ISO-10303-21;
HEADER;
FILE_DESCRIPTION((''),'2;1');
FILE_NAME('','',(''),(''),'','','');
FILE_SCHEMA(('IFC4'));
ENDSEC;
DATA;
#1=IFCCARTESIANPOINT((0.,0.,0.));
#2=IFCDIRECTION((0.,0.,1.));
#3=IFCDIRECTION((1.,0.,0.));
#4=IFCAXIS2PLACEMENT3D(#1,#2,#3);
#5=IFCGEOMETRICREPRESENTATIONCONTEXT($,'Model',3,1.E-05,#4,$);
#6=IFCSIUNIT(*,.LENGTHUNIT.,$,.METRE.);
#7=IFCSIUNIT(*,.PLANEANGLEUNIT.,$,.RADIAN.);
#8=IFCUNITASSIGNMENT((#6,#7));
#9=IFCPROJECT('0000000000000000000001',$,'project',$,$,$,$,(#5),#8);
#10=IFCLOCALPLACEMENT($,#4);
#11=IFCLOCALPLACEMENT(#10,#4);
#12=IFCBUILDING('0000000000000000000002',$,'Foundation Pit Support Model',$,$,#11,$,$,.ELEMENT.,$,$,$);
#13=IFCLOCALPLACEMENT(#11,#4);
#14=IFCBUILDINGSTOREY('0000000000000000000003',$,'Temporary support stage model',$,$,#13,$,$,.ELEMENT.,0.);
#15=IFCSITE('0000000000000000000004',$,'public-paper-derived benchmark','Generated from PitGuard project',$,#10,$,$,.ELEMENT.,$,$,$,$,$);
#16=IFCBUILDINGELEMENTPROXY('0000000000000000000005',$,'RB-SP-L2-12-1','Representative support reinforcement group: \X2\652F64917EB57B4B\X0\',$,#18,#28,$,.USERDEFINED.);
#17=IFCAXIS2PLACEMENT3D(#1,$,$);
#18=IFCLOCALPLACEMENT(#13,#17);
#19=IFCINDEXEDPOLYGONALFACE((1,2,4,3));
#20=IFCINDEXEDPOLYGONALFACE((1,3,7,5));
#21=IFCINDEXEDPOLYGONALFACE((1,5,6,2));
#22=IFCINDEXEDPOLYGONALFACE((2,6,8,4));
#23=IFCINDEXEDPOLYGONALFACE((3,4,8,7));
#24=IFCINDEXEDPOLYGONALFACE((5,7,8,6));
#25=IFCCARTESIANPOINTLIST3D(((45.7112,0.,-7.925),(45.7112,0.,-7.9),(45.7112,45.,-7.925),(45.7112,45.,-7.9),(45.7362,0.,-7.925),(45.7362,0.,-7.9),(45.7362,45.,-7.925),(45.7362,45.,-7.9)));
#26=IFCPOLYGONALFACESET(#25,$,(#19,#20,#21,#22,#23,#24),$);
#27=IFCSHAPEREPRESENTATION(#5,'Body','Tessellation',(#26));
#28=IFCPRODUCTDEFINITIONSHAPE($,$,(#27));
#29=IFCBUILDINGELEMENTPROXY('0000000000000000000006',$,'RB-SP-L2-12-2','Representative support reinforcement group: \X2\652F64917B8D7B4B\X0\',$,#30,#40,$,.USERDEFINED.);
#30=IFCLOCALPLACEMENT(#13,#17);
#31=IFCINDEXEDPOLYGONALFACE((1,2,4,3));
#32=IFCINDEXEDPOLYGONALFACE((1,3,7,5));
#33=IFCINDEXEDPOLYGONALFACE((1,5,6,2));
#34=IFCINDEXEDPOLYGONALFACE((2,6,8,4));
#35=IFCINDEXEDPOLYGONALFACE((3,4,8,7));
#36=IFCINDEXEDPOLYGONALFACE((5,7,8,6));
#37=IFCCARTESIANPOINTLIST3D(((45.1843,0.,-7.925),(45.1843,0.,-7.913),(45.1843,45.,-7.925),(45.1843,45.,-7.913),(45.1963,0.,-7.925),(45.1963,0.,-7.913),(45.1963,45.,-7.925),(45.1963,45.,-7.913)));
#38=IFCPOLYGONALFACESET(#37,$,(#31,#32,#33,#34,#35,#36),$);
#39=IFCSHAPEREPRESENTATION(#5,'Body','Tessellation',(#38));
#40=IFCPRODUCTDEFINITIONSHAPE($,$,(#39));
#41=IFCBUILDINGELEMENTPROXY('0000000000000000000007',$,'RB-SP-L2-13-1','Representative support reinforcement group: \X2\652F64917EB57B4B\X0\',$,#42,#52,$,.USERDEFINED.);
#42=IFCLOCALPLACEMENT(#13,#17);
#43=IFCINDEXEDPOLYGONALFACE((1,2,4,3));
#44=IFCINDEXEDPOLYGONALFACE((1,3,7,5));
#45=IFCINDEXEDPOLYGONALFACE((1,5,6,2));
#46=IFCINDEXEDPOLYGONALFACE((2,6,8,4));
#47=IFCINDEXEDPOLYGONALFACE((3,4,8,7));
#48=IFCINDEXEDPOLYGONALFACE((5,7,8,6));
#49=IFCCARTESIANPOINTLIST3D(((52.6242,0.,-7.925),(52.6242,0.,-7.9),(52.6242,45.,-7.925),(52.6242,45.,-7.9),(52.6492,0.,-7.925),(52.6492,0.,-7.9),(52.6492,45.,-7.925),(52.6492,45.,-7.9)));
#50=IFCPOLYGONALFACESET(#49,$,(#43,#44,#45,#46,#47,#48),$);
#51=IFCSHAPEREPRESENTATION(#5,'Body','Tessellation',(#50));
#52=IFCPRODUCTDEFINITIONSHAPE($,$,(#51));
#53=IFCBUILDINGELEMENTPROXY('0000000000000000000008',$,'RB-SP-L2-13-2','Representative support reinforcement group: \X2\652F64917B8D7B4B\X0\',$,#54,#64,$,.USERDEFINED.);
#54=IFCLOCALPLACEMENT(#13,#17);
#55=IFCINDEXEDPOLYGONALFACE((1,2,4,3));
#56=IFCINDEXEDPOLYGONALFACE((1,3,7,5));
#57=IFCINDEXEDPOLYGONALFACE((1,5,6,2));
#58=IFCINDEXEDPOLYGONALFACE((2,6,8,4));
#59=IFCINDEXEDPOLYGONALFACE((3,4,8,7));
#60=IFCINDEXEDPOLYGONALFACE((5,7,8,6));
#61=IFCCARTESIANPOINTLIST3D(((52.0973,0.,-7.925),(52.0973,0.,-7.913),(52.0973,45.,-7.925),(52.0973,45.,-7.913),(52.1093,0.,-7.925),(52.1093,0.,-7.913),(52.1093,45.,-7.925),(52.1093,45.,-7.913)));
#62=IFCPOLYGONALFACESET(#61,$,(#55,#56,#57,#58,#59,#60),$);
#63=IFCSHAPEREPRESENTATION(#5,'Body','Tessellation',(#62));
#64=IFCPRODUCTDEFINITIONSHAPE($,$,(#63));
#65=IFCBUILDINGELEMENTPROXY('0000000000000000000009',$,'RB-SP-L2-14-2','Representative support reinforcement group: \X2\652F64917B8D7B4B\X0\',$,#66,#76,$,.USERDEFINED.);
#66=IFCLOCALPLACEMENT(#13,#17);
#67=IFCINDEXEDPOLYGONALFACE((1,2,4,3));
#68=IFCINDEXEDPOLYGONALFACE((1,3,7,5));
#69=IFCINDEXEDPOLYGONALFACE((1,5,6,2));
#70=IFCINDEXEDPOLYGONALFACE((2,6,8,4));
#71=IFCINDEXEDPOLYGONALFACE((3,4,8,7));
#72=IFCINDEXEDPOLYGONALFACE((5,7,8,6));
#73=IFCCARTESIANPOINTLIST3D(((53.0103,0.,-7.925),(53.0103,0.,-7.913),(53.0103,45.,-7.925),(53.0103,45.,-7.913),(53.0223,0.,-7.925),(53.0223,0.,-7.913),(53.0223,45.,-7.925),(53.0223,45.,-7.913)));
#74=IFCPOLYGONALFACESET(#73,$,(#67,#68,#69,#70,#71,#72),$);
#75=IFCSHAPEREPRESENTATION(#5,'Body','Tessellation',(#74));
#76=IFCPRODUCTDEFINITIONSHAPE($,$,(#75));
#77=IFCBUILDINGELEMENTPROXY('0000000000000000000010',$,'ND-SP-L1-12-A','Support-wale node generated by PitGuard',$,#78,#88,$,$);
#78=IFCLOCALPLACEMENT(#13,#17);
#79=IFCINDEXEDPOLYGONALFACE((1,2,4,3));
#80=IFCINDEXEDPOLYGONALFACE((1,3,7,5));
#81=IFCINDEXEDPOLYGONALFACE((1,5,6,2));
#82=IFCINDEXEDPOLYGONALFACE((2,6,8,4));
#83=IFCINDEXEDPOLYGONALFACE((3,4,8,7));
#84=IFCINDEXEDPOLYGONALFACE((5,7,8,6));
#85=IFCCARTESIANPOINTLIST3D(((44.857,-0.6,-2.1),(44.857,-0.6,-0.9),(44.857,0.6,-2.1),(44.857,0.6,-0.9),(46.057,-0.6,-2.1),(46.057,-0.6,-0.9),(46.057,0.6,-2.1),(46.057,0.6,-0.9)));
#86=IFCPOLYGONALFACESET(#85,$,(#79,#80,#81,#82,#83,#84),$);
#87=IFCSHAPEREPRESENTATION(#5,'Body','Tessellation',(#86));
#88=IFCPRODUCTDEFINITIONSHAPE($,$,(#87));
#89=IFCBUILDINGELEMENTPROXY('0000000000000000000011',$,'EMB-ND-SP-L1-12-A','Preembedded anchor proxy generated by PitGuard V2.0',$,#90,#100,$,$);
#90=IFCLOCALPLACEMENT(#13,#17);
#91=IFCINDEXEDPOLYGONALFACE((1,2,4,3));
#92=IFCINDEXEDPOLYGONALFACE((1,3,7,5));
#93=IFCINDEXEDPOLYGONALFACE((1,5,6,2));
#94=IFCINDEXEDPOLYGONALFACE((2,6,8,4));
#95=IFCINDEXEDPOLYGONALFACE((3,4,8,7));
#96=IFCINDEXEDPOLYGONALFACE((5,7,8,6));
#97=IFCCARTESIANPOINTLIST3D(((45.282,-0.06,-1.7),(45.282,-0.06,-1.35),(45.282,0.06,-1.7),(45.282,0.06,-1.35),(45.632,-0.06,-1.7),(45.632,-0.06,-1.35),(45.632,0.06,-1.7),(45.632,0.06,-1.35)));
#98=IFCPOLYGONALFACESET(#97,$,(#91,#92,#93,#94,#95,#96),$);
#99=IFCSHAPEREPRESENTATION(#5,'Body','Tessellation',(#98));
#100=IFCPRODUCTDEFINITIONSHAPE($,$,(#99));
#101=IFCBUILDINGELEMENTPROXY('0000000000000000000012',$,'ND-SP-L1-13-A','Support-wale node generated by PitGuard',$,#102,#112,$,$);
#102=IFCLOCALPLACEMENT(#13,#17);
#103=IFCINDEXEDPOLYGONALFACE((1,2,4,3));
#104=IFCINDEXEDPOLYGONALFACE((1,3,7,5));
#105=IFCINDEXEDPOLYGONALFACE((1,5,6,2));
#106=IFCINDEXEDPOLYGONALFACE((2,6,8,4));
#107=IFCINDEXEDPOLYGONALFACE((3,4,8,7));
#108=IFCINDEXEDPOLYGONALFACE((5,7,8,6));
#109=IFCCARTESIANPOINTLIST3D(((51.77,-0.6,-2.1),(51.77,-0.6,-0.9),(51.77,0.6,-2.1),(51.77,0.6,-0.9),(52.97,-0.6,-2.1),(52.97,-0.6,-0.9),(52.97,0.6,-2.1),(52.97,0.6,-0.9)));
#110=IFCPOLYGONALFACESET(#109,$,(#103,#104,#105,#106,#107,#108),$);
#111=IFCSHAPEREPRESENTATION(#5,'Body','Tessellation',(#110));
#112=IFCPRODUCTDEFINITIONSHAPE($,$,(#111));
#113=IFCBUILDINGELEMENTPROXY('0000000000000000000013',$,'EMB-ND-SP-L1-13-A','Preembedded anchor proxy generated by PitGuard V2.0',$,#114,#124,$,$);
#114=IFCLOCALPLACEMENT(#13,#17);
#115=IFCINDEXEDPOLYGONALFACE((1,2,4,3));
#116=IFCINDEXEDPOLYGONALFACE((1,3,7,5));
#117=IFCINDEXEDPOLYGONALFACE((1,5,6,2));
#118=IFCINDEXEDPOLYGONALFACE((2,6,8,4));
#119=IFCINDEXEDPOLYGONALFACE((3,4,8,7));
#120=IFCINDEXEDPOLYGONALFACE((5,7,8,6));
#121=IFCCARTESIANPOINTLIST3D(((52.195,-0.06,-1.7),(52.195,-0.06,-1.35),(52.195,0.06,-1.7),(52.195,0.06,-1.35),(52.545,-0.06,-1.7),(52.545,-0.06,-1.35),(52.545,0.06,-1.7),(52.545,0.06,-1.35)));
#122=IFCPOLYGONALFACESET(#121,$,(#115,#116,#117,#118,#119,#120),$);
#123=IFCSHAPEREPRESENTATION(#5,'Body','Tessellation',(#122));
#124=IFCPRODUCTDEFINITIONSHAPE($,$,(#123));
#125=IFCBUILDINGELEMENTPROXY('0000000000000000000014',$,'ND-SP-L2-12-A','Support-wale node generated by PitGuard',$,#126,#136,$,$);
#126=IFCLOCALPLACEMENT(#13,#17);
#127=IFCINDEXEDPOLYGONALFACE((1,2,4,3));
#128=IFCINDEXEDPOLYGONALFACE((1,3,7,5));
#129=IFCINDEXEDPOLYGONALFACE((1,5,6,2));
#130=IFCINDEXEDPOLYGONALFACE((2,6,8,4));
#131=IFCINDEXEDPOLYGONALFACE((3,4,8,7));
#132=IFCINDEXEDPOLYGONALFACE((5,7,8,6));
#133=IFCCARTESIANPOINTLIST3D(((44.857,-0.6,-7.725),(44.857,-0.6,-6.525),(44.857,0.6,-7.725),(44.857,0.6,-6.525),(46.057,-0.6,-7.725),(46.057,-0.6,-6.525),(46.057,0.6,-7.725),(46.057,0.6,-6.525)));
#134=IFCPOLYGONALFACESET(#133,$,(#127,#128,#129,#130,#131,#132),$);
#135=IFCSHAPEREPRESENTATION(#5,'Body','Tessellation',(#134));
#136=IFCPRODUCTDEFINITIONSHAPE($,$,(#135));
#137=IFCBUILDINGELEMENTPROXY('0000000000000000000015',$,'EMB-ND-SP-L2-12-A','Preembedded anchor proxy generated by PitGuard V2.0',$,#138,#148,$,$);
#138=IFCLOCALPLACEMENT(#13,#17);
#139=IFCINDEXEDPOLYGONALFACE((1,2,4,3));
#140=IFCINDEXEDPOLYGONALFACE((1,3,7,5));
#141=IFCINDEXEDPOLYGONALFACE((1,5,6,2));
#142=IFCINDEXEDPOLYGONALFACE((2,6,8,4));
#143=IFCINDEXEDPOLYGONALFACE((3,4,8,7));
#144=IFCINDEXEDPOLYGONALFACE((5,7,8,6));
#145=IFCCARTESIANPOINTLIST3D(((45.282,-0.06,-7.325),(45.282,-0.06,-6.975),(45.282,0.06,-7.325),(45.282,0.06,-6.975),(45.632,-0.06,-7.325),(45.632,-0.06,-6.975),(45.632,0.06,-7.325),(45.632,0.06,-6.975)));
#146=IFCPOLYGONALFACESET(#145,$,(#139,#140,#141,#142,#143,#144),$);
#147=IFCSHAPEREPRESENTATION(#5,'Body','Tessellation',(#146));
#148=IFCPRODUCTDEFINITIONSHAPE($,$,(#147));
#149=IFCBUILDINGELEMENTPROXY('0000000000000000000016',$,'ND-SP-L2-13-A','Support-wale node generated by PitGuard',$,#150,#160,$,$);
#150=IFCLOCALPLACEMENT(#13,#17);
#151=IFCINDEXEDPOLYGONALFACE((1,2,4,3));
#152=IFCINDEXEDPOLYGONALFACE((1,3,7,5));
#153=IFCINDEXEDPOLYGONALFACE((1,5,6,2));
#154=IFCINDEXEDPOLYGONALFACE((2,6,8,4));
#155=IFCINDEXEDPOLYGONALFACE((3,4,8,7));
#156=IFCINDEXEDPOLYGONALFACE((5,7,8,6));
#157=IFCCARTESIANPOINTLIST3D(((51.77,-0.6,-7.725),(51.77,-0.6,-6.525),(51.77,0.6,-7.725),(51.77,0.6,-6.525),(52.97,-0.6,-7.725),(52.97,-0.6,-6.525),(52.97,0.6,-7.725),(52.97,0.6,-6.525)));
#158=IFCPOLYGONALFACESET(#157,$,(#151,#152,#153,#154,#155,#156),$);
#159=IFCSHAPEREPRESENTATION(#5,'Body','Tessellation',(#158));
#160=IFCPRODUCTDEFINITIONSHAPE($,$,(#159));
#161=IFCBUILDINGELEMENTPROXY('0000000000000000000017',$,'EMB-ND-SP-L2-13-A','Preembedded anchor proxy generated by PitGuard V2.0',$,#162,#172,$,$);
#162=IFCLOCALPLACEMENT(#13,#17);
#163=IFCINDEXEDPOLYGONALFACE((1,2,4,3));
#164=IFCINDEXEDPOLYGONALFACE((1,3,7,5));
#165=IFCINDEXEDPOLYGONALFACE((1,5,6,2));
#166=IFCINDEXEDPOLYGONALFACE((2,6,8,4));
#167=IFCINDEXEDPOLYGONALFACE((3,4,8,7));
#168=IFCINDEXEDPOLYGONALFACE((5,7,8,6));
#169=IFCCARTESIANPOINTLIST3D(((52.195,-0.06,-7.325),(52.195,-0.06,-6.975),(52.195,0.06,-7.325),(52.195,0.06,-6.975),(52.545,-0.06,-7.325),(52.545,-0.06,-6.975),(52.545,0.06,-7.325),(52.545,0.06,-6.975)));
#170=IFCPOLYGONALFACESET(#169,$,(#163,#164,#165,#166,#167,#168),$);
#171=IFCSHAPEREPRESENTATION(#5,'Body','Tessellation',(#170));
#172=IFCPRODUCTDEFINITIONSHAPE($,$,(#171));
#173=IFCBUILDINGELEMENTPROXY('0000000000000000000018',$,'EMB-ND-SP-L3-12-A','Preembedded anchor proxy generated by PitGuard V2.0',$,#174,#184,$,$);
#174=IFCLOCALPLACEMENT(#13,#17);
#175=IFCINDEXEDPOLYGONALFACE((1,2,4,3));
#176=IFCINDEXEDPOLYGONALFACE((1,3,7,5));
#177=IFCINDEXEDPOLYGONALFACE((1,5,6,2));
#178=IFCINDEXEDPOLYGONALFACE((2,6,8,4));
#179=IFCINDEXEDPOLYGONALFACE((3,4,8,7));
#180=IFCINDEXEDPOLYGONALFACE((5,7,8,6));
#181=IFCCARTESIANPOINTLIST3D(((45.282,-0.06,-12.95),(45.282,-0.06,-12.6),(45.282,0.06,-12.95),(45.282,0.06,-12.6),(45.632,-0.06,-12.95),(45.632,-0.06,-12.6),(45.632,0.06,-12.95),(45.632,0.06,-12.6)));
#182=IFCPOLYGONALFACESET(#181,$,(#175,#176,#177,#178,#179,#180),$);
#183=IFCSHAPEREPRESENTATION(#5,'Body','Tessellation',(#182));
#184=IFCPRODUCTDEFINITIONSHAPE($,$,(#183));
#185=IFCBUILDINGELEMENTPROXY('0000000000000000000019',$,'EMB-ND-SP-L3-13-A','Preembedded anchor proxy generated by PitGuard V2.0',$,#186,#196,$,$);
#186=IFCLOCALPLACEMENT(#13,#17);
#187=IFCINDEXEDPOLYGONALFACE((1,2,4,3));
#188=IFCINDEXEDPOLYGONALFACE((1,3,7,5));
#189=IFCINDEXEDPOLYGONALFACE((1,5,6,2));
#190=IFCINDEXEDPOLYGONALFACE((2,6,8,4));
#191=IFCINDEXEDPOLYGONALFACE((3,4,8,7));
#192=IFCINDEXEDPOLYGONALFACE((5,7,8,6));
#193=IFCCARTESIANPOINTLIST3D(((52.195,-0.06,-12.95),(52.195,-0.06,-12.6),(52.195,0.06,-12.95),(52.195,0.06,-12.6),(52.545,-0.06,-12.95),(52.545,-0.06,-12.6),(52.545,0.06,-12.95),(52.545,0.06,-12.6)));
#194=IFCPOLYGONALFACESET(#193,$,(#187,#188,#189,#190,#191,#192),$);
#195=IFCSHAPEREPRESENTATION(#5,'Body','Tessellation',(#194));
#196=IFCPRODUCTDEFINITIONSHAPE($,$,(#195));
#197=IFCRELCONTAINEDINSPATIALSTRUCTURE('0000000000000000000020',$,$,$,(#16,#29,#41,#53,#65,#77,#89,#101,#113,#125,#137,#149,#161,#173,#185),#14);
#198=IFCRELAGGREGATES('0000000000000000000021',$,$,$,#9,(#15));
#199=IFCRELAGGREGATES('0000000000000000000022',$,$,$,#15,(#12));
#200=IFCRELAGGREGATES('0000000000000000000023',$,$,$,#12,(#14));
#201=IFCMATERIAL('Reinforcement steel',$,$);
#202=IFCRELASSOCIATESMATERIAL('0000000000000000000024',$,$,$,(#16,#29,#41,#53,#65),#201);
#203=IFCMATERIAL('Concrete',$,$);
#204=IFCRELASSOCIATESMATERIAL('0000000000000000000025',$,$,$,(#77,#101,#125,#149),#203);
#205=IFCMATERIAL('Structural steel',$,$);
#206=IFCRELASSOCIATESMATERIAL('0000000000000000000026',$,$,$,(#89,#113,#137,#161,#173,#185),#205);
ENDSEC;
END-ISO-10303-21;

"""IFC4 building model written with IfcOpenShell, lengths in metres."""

from ifc_helpers import new_model, si_unit, frame, origin_with_axes, origin_2d, place, context, project, spatial, rectangle, extrude, material, element, save


model = new_model("IFC4")

# Units and contexts
model_context = context("Model", 3, precision=1e-05, world=origin_with_axes())
ifc_project = project(units=[si_unit("LENGTHUNIT", "METRE"), si_unit("PLANEANGLEUNIT", "RADIAN")], contexts=[model_context])

# Site, building, storey
site_placement = place(None, origin_with_axes())
site = spatial("IfcSite", under=ifc_project, at=site_placement, Name="public-paper-derived benchmark", Description="Generated from PitGuard project", CompositionType="ELEMENT")
building_placement = place(site_placement, origin_with_axes())
building = spatial("IfcBuilding", under=site, at=building_placement, Name="Foundation Pit Support Model", CompositionType="ELEMENT")
storey_placement = place(building_placement, origin_with_axes())
storey = spatial("IfcBuildingStorey", under=building, at=storey_placement, Name="Temporary support stage model", CompositionType="ELEMENT", Elevation=0.0)

# Shared definitions
ifc_material_1 = material(Name="Concrete")

# Shared definitions
ifc_material_2 = material(Name="Structural steel")

# Building element proxies
ifc_material_3 = material(Name="Reinforcement steel")
proxy_1_placement = place(storey_placement, frame((45.7237, 22.5, -7.925), z_axis=(0.0, 0.0, 1.0), x_axis=(0.0, 1.0, 0.0)))
element("IfcBuildingElementProxy", 1, at=proxy_1_placement, inside=storey, material=ifc_material_3, Name="RB-SP-L2-12-1", Description="Representative support reinforcement group: 支撑纵筋", PredefinedType="USERDEFINED", context=model_context, shape_type="SweptSolid", body=[
    extrude(rectangle(XDim=45.0, YDim=0.025, at=origin_2d()), origin_with_axes(), (0.0, 0.0, 1.0), 0.025),
])
proxy_2_placement = place(storey_placement, frame((45.1903, 22.5, -7.925), z_axis=(0.0, 0.0, 1.0), x_axis=(0.0, 1.0, 0.0)))
element("IfcBuildingElementProxy", 2, at=proxy_2_placement, inside=storey, material=ifc_material_3, Name="RB-SP-L2-12-2", Description="Representative support reinforcement group: 支撑箍筋", PredefinedType="USERDEFINED", context=model_context, shape_type="SweptSolid", body=[
    extrude(rectangle(XDim=45.0, YDim=0.012, at=origin_2d()), origin_with_axes(), (0.0, 0.0, 1.0), 0.012),
])
proxy_3_placement = place(storey_placement, frame((52.6367, 22.5, -7.925), z_axis=(0.0, 0.0, 1.0), x_axis=(0.0, 1.0, 0.0)))
element("IfcBuildingElementProxy", 3, at=proxy_3_placement, inside=storey, material=ifc_material_3, Name="RB-SP-L2-13-1", Description="Representative support reinforcement group: 支撑纵筋", PredefinedType="USERDEFINED", context=model_context, shape_type="SweptSolid", body=[
    extrude(rectangle(XDim=45.0, YDim=0.025, at=origin_2d()), origin_with_axes(), (0.0, 0.0, 1.0), 0.025),
])
for number, where, z_axis, x_axis, name in (
    (4, (52.1033, 22.5, -7.925), (0.0, 0.0, 1.0), (0.0, 1.0, 0.0), "RB-SP-L2-13-2"),
    (5, (53.0163, 22.5, -7.925), (0.0, 0.0, 1.0), (0.0, 1.0, 0.0), "RB-SP-L2-14-2"),
):
    element("IfcBuildingElementProxy", number, at=place(storey_placement, frame(where, z_axis=z_axis, x_axis=x_axis)), inside=storey, material=ifc_material_3, Name=name, Description="Representative support reinforcement group: 支撑箍筋", PredefinedType="USERDEFINED", context=model_context, shape_type="SweptSolid", body=[
        extrude(rectangle(XDim=45.0, YDim=0.012, at=origin_2d()), origin_with_axes(), (0.0, 0.0, 1.0), 0.012),
    ])
proxy_4_placement = place(storey_placement, frame((45.457, 0.0, -2.1), z_axis=(0.0, 0.0, 1.0), x_axis=(1.0, 0.0, 0.0)))
element("IfcBuildingElementProxy", 6, at=proxy_4_placement, inside=storey, material=ifc_material_1, Name="ND-SP-L1-12-A", Description="Support-wale node generated by PitGuard", context=model_context, shape_type="SweptSolid", body=[
    extrude(rectangle(XDim=1.2, YDim=1.2, at=origin_2d()), origin_with_axes(), (0.0, 0.0, 1.0), 1.2),
])
proxy_5_placement = place(storey_placement, frame((45.457, 0.0, -1.7), z_axis=(0.0, 0.0, 1.0), x_axis=(1.0, 0.0, 0.0)))
element("IfcBuildingElementProxy", 7, at=proxy_5_placement, inside=storey, material=ifc_material_2, Name="EMB-ND-SP-L1-12-A", Description="Preembedded anchor proxy generated by PitGuard V2.0", context=model_context, shape_type="SweptSolid", body=[
    extrude(rectangle(XDim=0.35, YDim=0.12, at=origin_2d()), origin_with_axes(), (0.0, 0.0, 1.0), 0.35),
])
proxy_6_placement = place(storey_placement, frame((52.37, 0.0, -2.1), z_axis=(0.0, 0.0, 1.0), x_axis=(1.0, 0.0, 0.0)))
element("IfcBuildingElementProxy", 8, at=proxy_6_placement, inside=storey, material=ifc_material_1, Name="ND-SP-L1-13-A", Description="Support-wale node generated by PitGuard", context=model_context, shape_type="SweptSolid", body=[
    extrude(rectangle(XDim=1.2, YDim=1.2, at=origin_2d()), origin_with_axes(), (0.0, 0.0, 1.0), 1.2),
])
proxy_7_placement = place(storey_placement, frame((52.37, 0.0, -1.7), z_axis=(0.0, 0.0, 1.0), x_axis=(1.0, 0.0, 0.0)))
element("IfcBuildingElementProxy", 9, at=proxy_7_placement, inside=storey, material=ifc_material_2, Name="EMB-ND-SP-L1-13-A", Description="Preembedded anchor proxy generated by PitGuard V2.0", context=model_context, shape_type="SweptSolid", body=[
    extrude(rectangle(XDim=0.35, YDim=0.12, at=origin_2d()), origin_with_axes(), (0.0, 0.0, 1.0), 0.35),
])
proxy_8_placement = place(storey_placement, frame((45.457, 0.0, -7.725), z_axis=(0.0, 0.0, 1.0), x_axis=(1.0, 0.0, 0.0)))
element("IfcBuildingElementProxy", 10, at=proxy_8_placement, inside=storey, material=ifc_material_1, Name="ND-SP-L2-12-A", Description="Support-wale node generated by PitGuard", context=model_context, shape_type="SweptSolid", body=[
    extrude(rectangle(XDim=1.2, YDim=1.2, at=origin_2d()), origin_with_axes(), (0.0, 0.0, 1.0), 1.2),
])
proxy_9_placement = place(storey_placement, frame((45.457, 0.0, -7.325), z_axis=(0.0, 0.0, 1.0), x_axis=(1.0, 0.0, 0.0)))
element("IfcBuildingElementProxy", 11, at=proxy_9_placement, inside=storey, material=ifc_material_2, Name="EMB-ND-SP-L2-12-A", Description="Preembedded anchor proxy generated by PitGuard V2.0", context=model_context, shape_type="SweptSolid", body=[
    extrude(rectangle(XDim=0.35, YDim=0.12, at=origin_2d()), origin_with_axes(), (0.0, 0.0, 1.0), 0.35),
])
proxy_10_placement = place(storey_placement, frame((52.37, 0.0, -7.725), z_axis=(0.0, 0.0, 1.0), x_axis=(1.0, 0.0, 0.0)))
element("IfcBuildingElementProxy", 12, at=proxy_10_placement, inside=storey, material=ifc_material_1, Name="ND-SP-L2-13-A", Description="Support-wale node generated by PitGuard", context=model_context, shape_type="SweptSolid", body=[
    extrude(rectangle(XDim=1.2, YDim=1.2, at=origin_2d()), origin_with_axes(), (0.0, 0.0, 1.0), 1.2),
])
for number, where, z_axis, x_axis, name in (
    (13, (52.37, 0.0, -7.325), (0.0, 0.0, 1.0), (1.0, 0.0, 0.0), "EMB-ND-SP-L2-13-A"),
    (14, (45.457, 0.0, -12.95), (0.0, 0.0, 1.0), (1.0, 0.0, 0.0), "EMB-ND-SP-L3-12-A"),
    (15, (52.37, 0.0, -12.95), (0.0, 0.0, 1.0), (1.0, 0.0, 0.0), "EMB-ND-SP-L3-13-A"),
):
    element("IfcBuildingElementProxy", number, at=place(storey_placement, frame(where, z_axis=z_axis, x_axis=x_axis)), inside=storey, material=ifc_material_2, Name=name, Description="Preembedded anchor proxy generated by PitGuard V2.0", context=model_context, shape_type="SweptSolid", body=[
        extrude(rectangle(XDim=0.35, YDim=0.12, at=origin_2d()), origin_with_axes(), (0.0, 0.0, 1.0), 0.35),
    ])

save(model, "model.ifc")
